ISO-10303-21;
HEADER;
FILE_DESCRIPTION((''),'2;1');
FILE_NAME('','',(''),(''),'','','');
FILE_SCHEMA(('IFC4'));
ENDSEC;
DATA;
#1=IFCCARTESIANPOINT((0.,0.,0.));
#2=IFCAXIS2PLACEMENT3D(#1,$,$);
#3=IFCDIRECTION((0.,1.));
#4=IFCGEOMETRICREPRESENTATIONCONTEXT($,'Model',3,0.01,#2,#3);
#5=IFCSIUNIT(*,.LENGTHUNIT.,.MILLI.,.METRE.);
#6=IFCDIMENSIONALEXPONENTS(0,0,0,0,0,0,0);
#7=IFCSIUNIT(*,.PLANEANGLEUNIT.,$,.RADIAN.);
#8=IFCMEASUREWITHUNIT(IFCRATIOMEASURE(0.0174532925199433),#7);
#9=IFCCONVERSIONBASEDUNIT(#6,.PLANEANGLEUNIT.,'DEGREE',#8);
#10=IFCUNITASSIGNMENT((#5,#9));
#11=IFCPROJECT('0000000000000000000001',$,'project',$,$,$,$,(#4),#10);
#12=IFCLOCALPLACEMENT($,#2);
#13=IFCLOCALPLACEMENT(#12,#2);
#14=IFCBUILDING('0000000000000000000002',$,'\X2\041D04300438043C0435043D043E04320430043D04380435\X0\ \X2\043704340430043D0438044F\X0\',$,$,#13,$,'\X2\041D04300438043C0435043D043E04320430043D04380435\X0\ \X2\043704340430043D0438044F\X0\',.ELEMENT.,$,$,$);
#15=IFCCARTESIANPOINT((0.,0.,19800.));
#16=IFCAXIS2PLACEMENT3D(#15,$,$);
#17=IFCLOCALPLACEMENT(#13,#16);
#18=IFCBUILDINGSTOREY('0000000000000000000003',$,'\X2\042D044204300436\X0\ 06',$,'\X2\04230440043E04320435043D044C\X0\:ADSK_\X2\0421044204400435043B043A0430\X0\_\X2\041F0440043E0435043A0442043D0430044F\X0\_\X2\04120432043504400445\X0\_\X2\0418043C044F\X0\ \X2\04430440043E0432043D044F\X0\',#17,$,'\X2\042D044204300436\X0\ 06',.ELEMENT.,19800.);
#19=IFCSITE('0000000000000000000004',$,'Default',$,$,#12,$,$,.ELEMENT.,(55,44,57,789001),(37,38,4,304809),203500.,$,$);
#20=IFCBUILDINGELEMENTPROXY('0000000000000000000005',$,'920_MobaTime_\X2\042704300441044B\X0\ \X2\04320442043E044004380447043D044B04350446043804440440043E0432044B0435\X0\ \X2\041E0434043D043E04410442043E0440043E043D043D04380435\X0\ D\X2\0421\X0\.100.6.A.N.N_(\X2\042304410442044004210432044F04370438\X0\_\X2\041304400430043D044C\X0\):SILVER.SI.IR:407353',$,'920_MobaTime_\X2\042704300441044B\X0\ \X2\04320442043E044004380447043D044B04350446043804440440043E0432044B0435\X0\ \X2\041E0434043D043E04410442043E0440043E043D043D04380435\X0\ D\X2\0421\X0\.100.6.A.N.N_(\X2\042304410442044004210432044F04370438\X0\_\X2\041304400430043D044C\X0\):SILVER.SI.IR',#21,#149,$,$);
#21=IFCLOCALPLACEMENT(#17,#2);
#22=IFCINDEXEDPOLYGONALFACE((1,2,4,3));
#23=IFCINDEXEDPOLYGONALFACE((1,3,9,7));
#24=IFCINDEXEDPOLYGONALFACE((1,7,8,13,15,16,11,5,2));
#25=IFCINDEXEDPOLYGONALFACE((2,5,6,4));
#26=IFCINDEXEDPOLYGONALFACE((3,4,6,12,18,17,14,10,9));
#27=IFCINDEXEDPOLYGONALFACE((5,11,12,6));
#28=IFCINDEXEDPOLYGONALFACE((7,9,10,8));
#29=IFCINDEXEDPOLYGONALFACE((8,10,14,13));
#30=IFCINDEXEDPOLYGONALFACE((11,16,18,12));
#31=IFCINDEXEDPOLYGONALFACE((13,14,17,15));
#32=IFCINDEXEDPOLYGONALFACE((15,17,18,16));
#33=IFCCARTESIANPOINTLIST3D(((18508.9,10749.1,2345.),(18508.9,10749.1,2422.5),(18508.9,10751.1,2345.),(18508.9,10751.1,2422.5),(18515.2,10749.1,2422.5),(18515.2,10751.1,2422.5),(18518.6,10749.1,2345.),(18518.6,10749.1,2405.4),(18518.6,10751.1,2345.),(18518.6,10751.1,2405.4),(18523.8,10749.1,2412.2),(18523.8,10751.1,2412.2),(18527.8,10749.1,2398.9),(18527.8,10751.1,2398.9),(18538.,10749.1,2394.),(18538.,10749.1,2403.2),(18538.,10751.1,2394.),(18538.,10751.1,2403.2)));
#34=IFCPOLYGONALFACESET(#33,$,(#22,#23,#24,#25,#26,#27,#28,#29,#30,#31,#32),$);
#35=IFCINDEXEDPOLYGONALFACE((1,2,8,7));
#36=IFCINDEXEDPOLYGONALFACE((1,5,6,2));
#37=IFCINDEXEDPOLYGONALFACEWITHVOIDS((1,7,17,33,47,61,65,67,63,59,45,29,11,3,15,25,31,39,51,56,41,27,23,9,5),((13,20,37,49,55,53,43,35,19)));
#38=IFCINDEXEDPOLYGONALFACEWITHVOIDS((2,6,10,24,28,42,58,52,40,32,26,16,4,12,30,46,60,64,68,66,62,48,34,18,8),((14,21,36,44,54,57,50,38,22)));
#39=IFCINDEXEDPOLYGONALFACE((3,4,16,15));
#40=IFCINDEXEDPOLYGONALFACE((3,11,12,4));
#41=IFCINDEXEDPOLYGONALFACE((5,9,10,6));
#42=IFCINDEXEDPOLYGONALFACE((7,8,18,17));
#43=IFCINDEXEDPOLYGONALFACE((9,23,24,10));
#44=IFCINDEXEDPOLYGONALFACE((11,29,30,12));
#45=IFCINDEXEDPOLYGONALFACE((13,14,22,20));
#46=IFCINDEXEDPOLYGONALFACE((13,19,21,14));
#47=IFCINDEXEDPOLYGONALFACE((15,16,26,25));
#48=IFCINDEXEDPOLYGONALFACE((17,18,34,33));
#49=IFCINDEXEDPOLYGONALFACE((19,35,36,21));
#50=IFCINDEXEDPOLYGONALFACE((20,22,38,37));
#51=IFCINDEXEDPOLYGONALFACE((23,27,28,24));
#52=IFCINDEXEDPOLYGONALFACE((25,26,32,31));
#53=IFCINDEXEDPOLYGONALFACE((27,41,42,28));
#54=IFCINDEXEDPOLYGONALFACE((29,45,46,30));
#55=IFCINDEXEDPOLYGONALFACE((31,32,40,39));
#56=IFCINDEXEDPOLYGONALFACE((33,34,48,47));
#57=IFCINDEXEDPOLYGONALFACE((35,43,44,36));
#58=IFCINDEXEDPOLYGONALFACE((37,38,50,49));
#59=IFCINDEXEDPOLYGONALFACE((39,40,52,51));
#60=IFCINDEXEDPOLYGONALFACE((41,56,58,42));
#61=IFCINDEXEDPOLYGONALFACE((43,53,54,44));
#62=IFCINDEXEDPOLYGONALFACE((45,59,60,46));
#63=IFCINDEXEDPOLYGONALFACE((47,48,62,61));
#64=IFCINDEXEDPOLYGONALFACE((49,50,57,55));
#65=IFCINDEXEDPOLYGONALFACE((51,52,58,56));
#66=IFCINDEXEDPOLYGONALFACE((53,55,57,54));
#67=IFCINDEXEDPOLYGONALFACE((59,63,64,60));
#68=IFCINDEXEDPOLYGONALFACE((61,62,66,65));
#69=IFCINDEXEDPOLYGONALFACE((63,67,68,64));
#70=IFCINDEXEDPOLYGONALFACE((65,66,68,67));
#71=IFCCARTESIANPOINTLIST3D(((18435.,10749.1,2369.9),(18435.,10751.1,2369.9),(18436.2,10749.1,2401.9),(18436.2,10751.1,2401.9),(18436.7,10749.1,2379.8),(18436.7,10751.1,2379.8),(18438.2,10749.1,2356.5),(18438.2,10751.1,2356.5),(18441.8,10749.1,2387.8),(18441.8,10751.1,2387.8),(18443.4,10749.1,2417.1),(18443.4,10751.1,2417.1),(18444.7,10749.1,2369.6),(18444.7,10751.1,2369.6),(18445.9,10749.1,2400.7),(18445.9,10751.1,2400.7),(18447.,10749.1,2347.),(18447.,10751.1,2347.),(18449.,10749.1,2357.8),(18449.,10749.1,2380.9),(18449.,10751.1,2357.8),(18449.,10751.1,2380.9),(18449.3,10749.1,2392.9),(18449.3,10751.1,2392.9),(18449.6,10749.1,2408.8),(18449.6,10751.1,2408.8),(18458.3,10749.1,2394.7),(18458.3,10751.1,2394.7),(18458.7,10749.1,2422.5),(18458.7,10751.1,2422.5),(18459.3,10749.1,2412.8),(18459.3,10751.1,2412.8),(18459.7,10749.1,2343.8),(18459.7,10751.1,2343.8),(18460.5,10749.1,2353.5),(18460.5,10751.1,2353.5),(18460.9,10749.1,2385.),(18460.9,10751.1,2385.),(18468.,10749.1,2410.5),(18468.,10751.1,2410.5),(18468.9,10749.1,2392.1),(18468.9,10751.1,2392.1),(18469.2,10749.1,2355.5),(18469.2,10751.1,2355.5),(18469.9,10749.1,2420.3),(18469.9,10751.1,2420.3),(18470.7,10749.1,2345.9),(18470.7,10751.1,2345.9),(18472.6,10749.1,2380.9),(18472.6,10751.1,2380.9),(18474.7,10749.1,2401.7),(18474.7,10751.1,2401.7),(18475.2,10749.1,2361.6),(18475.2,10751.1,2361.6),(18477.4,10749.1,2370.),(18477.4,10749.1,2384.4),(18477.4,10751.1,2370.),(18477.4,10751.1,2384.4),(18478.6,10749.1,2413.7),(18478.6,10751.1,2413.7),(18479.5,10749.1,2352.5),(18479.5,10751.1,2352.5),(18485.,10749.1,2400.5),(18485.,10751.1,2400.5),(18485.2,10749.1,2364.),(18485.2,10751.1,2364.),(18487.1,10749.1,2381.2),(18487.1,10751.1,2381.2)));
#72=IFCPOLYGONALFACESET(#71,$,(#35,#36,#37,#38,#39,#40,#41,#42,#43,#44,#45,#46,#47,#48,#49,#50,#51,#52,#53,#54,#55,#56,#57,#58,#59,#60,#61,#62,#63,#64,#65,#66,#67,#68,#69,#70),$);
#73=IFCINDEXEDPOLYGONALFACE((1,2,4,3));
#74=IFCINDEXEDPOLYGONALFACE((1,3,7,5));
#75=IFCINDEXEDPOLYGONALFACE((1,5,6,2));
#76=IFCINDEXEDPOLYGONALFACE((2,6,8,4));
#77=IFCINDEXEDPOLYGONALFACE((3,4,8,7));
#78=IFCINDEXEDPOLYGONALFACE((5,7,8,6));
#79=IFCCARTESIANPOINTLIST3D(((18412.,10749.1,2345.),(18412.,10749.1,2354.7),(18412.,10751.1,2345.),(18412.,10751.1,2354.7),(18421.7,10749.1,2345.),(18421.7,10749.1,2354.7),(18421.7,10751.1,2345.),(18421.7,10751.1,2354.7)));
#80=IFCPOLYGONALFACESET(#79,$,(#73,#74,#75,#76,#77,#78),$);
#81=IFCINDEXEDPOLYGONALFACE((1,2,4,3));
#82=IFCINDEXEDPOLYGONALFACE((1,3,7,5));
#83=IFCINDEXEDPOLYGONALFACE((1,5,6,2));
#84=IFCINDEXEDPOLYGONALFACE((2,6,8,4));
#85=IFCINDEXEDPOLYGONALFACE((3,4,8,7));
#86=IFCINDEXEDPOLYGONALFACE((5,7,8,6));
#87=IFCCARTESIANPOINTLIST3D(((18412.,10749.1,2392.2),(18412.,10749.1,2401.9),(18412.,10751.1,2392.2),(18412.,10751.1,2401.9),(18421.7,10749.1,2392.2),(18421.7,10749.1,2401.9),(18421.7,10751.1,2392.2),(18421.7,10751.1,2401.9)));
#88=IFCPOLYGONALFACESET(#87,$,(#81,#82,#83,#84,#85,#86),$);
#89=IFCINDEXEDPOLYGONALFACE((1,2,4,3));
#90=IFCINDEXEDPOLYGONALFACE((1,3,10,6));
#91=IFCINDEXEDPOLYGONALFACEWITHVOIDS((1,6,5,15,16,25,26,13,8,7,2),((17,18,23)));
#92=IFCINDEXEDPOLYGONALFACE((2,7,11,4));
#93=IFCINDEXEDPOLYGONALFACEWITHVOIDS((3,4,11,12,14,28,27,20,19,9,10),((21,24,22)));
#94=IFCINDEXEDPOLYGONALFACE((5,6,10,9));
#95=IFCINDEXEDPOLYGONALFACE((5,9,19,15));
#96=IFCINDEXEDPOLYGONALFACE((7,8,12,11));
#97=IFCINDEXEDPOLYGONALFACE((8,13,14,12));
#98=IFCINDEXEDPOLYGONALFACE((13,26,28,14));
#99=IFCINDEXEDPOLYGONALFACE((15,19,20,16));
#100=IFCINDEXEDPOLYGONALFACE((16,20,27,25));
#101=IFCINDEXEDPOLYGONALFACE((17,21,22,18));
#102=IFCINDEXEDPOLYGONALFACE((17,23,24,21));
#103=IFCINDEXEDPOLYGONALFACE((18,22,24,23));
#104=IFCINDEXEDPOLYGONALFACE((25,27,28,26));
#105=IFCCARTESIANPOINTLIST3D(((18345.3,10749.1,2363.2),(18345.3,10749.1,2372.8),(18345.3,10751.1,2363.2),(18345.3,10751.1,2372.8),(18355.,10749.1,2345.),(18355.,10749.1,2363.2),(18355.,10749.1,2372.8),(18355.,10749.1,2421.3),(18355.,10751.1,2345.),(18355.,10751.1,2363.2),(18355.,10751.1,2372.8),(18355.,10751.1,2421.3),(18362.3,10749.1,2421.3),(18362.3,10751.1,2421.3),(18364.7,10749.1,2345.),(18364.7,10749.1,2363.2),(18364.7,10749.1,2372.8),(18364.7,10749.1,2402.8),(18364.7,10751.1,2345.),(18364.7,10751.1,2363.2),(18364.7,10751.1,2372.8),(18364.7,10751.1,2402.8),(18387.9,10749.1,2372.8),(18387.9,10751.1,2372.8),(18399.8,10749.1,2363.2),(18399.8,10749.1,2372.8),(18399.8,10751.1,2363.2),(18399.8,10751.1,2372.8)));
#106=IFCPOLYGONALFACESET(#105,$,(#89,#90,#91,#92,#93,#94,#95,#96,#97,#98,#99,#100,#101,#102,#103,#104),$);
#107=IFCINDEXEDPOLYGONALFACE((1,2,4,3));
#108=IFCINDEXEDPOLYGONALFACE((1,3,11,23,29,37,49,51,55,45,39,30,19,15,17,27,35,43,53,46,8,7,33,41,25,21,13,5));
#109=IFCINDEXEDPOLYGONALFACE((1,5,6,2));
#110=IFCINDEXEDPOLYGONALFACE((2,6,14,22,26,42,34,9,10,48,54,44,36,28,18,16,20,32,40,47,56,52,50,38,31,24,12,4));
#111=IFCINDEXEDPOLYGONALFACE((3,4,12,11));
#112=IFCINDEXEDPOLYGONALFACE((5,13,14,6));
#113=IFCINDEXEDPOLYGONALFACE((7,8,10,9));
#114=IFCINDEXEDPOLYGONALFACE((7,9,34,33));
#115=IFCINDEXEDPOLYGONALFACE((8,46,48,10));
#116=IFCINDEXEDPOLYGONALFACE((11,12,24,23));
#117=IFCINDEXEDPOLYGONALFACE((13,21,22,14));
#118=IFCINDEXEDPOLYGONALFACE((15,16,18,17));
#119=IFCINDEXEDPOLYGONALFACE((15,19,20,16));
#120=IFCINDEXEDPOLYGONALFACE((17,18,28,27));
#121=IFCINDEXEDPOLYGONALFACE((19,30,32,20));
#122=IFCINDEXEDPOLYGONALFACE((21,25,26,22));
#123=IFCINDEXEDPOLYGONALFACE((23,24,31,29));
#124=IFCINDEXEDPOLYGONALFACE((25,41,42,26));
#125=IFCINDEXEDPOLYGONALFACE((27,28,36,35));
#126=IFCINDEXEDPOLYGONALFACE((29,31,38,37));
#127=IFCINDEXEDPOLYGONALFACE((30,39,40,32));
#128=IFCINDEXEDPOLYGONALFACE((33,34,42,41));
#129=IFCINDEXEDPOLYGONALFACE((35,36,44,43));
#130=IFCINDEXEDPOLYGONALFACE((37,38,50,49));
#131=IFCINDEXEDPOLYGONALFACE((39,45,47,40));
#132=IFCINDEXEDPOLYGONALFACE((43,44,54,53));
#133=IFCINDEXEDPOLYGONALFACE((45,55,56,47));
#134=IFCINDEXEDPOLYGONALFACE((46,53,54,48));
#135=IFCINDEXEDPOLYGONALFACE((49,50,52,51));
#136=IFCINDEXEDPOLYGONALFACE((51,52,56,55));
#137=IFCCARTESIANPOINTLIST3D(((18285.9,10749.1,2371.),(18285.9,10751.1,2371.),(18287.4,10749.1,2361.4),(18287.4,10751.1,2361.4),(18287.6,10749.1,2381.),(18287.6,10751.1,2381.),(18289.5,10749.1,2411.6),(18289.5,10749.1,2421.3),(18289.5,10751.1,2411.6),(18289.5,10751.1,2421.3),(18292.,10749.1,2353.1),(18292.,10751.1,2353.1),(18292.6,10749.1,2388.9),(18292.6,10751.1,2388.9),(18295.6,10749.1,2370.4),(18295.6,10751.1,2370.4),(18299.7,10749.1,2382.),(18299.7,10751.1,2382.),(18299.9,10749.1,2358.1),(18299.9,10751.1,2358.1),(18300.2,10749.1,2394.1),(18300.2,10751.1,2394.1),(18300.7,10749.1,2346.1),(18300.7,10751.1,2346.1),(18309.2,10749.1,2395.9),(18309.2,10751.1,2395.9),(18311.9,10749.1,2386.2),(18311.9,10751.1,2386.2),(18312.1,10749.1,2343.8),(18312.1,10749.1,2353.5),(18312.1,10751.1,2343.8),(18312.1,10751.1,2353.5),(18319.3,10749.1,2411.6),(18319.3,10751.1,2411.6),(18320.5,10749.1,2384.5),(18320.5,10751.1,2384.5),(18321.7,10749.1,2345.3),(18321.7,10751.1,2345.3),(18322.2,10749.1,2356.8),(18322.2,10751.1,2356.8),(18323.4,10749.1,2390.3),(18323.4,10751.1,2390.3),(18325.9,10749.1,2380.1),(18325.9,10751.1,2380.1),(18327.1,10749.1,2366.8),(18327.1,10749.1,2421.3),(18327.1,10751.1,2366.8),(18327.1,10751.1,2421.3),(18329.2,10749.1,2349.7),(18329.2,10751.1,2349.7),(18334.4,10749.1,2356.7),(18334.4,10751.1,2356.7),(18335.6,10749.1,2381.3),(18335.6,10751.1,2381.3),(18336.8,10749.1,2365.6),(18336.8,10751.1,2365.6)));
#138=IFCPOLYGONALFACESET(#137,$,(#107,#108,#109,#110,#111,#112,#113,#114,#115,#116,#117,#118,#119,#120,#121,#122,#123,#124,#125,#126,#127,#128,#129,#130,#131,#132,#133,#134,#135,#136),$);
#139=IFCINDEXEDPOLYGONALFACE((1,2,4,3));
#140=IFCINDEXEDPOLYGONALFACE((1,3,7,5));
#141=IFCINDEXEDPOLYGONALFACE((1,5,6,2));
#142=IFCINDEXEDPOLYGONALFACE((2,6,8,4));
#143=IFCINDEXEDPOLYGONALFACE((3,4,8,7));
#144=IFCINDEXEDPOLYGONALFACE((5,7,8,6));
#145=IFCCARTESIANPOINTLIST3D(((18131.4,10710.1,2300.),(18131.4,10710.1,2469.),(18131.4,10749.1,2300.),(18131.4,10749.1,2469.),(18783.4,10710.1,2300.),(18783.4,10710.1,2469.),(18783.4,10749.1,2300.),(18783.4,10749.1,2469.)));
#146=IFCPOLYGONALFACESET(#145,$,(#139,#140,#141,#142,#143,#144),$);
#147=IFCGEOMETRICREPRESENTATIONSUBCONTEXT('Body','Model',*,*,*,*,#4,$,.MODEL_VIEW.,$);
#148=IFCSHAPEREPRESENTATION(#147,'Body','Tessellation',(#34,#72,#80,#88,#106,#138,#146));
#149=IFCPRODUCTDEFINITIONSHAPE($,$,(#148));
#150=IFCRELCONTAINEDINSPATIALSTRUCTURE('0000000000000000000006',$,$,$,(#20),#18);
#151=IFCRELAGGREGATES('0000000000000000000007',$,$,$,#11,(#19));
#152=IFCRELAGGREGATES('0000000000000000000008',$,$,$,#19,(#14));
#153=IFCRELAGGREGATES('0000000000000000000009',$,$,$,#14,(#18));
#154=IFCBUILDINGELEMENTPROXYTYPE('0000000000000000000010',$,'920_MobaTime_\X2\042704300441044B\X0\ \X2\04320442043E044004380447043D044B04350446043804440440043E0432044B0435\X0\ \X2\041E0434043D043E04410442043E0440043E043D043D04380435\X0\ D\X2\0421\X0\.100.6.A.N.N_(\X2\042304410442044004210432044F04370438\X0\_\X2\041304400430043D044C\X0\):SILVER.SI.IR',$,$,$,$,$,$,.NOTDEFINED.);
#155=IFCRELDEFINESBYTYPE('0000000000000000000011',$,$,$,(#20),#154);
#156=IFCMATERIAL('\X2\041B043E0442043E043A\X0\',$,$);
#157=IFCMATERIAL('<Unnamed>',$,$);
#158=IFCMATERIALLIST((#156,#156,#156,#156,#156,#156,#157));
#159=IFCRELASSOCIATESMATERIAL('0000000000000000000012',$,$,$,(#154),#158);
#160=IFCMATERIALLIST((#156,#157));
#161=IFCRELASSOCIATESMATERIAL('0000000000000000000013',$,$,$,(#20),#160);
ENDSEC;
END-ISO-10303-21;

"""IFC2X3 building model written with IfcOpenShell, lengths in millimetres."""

from ifc_helpers import new_model, entity, si_unit, converted_unit, direction, frame, origin, origin_2d_with_axis, place, context, subcontext, project, spatial, polyline, rectangle, outline, extrude, source, transform, mapped, material, material_list, type_object, type_shapes, element, save


model = new_model("IFC2X3")

# Units and contexts
model_context = context("Model", 3, precision=0.01, world=origin(), true_north=direction((0.0, 1.0)))
body_context = subcontext(model_context, "Body", "Model", "MODEL_VIEW")
ifc_project = project(units=[si_unit("LENGTHUNIT", "METRE", prefix="MILLI"), converted_unit("PLANEANGLEUNIT", "DEGREE", entity("IfcRatioMeasure", 0.0174532925199433), si_unit("PLANEANGLEUNIT", "RADIAN"), dimensions=[0, 0, 0, 0, 0, 0, 0])], contexts=[model_context])

# Site, building, storey
site_placement = place(None, frame((0.0, 0.0, 0.0)))
site = spatial("IfcSite", under=ifc_project, at=site_placement, Name="Default", CompositionType="ELEMENT", RefLatitude=(55, 44, 57, 789001), RefLongitude=(37, 38, 4, 304809), RefElevation=203500.0)
building_placement = place(site_placement, origin())
building = spatial("IfcBuilding", under=site, at=building_placement, Name="Наименование здания", LongName="Наименование здания", CompositionType="ELEMENT")
storey_placement = place(building_placement, frame((0.0, 0.0, 19800.0)))
storey = spatial("IfcBuildingStorey", under=building, at=storey_placement, Name="Этаж 06", ObjectType="Уровень:ADSK_Стрелка_Проектная_Вверх_Имя уровня", LongName="Этаж 06", CompositionType="ELEMENT", Elevation=19800.0)

# Building element proxy
ifc_material_1 = material(Name="Лоток")
ifc_material_2 = material(Name="<Unnamed>")
ifc_material_list_1 = material_list([ifc_material_1, ifc_material_1, ifc_material_1, ifc_material_1, ifc_material_1, ifc_material_1, ifc_material_2])
building_element_proxy_type_1 = type_object("IfcBuildingElementProxyType", Name="920_MobaTime_Часы вторичныецифровые Односторонние DС.100.6.A.N.N_(УстрСвязи_Грань):SILVER.SI.IR", PredefinedType="NOTDEFINED", material=ifc_material_list_1)
shared_shape_1 = source(origin(), body_context, "Body", "SweptSolid", [
    extrude(outline(polyline([(-49.3, -13.1), (28.2, -13.1), (28.2, -6.8), (17.9, 1.8), (8.9, 16.0), (-0.3, 16.0), (4.6, 5.8), (11.1, -3.4), (-49.3, -3.4), (-49.3, -13.1)])), frame((-64.6, 9.8, 39.0), z_axis=(0.0, 0.0, 1.0), x_axis=(0.0, 1.0, 0.0)), (0.0, 0.0, 1.0), 2.0),
    extrude(outline(polyline([(2.2, -27.6), (19.0, -27.6), (30.5, -16.1), (33.3, -4.9), (31.0, 5.8), (21.8, 17.2), (5.2, 27.3), (-11.1, 33.0), (-24.0, 32.7), (-33.6, 27.6), (-40.3, 18.6), (-42.8, 5.7), (-38.0, -6.3), (-27.2, -15.0), (-17.5, -17.7), (-8.2, -16.4), (-0.3, -11.9), (5.1, -4.5), (7.3, 6.2), (4.0, 17.2), (18.5, 7.3), (23.6, -2.4), (22.0, -11.4), (14.2, -18.4), (5.3, -18.3), (2.2, -27.6)]), holes=[polyline([(-9.0, 23.3), (-1.3, 14.4), (-2.6, 2.0), (-11.4, -7.0), (-23.4, -6.1), (-32.2, 2.9), (-31.2, 15.1), (-25.6, 22.1), (-17.5, 24.9), (-9.0, 23.3)])]), frame((-2.7, 3.6, 39.0), z_axis=(0.0, 0.0, 1.0), x_axis=(-0.427649, 0.903945, 0.0)), (0.0, 0.0, 1.0), 2.0),
    extrude(rectangle(XDim=9.7, YDim=9.7, at=origin_2d_with_axis()), frame((40.6, -34.7, 39.0)), (0.0, 0.0, 1.0), 2.0),
    extrude(rectangle(XDim=9.7, YDim=9.7, at=origin_2d_with_axis()), frame((40.6, 12.6, 39.0)), (0.0, 0.0, 1.0), 2.0),
    extrude(outline(polyline([(-0.9, -28.1), (8.8, -28.1), (8.8, -9.9), (18.5, -9.9), (18.5, -0.2), (8.8, -0.2), (8.8, 48.3), (1.5, 48.3), (-36.0, -0.2), (-36.0, -9.9), (-0.9, -9.9), (-0.9, -28.1)]), holes=[polyline([(-0.9, -0.2), (-24.1, -0.2), (-0.9, 29.7), (-0.9, -0.2)])]), frame((93.6, -11.4, 39.0)), (0.0, 0.0, 1.0), 2.0),
    extrude(outline(polyline([(3.3, -28.3), (12.5, -28.3), (20.5, -25.0), (26.8, -18.8), (30.7, -10.0), (31.4, 1.6), (26.9, 11.8), (20.1, 18.4), (11.1, 22.3), (1.0, 23.3), (-7.9, 20.4), (-14.9, 14.5), (-18.9, 6.2), (-17.1, -9.0), (-36.7, 0.5), (-29.1, 29.3), (-38.5, 31.7), (-48.1, -4.6), (-11.6, -23.0), (-8.0, -14.0), (-10.8, -7.6), (-10.2, 1.1), (-3.0, 11.8), (9.2, 12.8), (20.0, 5.4), (21.3, -7.5), (15.5, -16.4), (4.6, -18.6), (3.3, -28.3)])), frame((147.1, -8.5, 39.0), z_axis=(0.0, 0.0, 1.0), x_axis=(0.256974, -0.966418, 0.0)), (0.0, 0.0, 1.0), 2.0),
    extrude(rectangle(XDim=652.0, YDim=169.0, at=origin_2d_with_axis()), frame((0.0, 0.0, 0.0), z_axis=(0.0, 0.0, 1.0), x_axis=(-1.0, 0.0, 0.0)), (0.0, 0.0, 1.0), 39.0),
])
type_shapes(building_element_proxy_type_1, [shared_shape_1])
ifc_material_list_2 = material_list([ifc_material_1, ifc_material_2])
proxy_1_placement = place(storey_placement, frame((18457.4, 10710.1, 2384.5), z_axis=(0.0, 1.0, 0.0), x_axis=(-1.0, 0.0, 0.0)))
element("IfcBuildingElementProxy", 1, at=proxy_1_placement, inside=storey, type_object=building_element_proxy_type_1, material=ifc_material_list_2, Name="920_MobaTime_Часы вторичныецифровые Односторонние DС.100.6.A.N.N_(УстрСвязи_Грань):SILVER.SI.IR:407353", ObjectType="920_MobaTime_Часы вторичныецифровые Односторонние DС.100.6.A.N.N_(УстрСвязи_Грань):SILVER.SI.IR", context=body_context, shape_type="MappedRepresentation", body=[
    mapped(shared_shape_1, transform((0.0, 0.0, 0.0), scale=1.0)),
])

save(model, "model.ifc")
